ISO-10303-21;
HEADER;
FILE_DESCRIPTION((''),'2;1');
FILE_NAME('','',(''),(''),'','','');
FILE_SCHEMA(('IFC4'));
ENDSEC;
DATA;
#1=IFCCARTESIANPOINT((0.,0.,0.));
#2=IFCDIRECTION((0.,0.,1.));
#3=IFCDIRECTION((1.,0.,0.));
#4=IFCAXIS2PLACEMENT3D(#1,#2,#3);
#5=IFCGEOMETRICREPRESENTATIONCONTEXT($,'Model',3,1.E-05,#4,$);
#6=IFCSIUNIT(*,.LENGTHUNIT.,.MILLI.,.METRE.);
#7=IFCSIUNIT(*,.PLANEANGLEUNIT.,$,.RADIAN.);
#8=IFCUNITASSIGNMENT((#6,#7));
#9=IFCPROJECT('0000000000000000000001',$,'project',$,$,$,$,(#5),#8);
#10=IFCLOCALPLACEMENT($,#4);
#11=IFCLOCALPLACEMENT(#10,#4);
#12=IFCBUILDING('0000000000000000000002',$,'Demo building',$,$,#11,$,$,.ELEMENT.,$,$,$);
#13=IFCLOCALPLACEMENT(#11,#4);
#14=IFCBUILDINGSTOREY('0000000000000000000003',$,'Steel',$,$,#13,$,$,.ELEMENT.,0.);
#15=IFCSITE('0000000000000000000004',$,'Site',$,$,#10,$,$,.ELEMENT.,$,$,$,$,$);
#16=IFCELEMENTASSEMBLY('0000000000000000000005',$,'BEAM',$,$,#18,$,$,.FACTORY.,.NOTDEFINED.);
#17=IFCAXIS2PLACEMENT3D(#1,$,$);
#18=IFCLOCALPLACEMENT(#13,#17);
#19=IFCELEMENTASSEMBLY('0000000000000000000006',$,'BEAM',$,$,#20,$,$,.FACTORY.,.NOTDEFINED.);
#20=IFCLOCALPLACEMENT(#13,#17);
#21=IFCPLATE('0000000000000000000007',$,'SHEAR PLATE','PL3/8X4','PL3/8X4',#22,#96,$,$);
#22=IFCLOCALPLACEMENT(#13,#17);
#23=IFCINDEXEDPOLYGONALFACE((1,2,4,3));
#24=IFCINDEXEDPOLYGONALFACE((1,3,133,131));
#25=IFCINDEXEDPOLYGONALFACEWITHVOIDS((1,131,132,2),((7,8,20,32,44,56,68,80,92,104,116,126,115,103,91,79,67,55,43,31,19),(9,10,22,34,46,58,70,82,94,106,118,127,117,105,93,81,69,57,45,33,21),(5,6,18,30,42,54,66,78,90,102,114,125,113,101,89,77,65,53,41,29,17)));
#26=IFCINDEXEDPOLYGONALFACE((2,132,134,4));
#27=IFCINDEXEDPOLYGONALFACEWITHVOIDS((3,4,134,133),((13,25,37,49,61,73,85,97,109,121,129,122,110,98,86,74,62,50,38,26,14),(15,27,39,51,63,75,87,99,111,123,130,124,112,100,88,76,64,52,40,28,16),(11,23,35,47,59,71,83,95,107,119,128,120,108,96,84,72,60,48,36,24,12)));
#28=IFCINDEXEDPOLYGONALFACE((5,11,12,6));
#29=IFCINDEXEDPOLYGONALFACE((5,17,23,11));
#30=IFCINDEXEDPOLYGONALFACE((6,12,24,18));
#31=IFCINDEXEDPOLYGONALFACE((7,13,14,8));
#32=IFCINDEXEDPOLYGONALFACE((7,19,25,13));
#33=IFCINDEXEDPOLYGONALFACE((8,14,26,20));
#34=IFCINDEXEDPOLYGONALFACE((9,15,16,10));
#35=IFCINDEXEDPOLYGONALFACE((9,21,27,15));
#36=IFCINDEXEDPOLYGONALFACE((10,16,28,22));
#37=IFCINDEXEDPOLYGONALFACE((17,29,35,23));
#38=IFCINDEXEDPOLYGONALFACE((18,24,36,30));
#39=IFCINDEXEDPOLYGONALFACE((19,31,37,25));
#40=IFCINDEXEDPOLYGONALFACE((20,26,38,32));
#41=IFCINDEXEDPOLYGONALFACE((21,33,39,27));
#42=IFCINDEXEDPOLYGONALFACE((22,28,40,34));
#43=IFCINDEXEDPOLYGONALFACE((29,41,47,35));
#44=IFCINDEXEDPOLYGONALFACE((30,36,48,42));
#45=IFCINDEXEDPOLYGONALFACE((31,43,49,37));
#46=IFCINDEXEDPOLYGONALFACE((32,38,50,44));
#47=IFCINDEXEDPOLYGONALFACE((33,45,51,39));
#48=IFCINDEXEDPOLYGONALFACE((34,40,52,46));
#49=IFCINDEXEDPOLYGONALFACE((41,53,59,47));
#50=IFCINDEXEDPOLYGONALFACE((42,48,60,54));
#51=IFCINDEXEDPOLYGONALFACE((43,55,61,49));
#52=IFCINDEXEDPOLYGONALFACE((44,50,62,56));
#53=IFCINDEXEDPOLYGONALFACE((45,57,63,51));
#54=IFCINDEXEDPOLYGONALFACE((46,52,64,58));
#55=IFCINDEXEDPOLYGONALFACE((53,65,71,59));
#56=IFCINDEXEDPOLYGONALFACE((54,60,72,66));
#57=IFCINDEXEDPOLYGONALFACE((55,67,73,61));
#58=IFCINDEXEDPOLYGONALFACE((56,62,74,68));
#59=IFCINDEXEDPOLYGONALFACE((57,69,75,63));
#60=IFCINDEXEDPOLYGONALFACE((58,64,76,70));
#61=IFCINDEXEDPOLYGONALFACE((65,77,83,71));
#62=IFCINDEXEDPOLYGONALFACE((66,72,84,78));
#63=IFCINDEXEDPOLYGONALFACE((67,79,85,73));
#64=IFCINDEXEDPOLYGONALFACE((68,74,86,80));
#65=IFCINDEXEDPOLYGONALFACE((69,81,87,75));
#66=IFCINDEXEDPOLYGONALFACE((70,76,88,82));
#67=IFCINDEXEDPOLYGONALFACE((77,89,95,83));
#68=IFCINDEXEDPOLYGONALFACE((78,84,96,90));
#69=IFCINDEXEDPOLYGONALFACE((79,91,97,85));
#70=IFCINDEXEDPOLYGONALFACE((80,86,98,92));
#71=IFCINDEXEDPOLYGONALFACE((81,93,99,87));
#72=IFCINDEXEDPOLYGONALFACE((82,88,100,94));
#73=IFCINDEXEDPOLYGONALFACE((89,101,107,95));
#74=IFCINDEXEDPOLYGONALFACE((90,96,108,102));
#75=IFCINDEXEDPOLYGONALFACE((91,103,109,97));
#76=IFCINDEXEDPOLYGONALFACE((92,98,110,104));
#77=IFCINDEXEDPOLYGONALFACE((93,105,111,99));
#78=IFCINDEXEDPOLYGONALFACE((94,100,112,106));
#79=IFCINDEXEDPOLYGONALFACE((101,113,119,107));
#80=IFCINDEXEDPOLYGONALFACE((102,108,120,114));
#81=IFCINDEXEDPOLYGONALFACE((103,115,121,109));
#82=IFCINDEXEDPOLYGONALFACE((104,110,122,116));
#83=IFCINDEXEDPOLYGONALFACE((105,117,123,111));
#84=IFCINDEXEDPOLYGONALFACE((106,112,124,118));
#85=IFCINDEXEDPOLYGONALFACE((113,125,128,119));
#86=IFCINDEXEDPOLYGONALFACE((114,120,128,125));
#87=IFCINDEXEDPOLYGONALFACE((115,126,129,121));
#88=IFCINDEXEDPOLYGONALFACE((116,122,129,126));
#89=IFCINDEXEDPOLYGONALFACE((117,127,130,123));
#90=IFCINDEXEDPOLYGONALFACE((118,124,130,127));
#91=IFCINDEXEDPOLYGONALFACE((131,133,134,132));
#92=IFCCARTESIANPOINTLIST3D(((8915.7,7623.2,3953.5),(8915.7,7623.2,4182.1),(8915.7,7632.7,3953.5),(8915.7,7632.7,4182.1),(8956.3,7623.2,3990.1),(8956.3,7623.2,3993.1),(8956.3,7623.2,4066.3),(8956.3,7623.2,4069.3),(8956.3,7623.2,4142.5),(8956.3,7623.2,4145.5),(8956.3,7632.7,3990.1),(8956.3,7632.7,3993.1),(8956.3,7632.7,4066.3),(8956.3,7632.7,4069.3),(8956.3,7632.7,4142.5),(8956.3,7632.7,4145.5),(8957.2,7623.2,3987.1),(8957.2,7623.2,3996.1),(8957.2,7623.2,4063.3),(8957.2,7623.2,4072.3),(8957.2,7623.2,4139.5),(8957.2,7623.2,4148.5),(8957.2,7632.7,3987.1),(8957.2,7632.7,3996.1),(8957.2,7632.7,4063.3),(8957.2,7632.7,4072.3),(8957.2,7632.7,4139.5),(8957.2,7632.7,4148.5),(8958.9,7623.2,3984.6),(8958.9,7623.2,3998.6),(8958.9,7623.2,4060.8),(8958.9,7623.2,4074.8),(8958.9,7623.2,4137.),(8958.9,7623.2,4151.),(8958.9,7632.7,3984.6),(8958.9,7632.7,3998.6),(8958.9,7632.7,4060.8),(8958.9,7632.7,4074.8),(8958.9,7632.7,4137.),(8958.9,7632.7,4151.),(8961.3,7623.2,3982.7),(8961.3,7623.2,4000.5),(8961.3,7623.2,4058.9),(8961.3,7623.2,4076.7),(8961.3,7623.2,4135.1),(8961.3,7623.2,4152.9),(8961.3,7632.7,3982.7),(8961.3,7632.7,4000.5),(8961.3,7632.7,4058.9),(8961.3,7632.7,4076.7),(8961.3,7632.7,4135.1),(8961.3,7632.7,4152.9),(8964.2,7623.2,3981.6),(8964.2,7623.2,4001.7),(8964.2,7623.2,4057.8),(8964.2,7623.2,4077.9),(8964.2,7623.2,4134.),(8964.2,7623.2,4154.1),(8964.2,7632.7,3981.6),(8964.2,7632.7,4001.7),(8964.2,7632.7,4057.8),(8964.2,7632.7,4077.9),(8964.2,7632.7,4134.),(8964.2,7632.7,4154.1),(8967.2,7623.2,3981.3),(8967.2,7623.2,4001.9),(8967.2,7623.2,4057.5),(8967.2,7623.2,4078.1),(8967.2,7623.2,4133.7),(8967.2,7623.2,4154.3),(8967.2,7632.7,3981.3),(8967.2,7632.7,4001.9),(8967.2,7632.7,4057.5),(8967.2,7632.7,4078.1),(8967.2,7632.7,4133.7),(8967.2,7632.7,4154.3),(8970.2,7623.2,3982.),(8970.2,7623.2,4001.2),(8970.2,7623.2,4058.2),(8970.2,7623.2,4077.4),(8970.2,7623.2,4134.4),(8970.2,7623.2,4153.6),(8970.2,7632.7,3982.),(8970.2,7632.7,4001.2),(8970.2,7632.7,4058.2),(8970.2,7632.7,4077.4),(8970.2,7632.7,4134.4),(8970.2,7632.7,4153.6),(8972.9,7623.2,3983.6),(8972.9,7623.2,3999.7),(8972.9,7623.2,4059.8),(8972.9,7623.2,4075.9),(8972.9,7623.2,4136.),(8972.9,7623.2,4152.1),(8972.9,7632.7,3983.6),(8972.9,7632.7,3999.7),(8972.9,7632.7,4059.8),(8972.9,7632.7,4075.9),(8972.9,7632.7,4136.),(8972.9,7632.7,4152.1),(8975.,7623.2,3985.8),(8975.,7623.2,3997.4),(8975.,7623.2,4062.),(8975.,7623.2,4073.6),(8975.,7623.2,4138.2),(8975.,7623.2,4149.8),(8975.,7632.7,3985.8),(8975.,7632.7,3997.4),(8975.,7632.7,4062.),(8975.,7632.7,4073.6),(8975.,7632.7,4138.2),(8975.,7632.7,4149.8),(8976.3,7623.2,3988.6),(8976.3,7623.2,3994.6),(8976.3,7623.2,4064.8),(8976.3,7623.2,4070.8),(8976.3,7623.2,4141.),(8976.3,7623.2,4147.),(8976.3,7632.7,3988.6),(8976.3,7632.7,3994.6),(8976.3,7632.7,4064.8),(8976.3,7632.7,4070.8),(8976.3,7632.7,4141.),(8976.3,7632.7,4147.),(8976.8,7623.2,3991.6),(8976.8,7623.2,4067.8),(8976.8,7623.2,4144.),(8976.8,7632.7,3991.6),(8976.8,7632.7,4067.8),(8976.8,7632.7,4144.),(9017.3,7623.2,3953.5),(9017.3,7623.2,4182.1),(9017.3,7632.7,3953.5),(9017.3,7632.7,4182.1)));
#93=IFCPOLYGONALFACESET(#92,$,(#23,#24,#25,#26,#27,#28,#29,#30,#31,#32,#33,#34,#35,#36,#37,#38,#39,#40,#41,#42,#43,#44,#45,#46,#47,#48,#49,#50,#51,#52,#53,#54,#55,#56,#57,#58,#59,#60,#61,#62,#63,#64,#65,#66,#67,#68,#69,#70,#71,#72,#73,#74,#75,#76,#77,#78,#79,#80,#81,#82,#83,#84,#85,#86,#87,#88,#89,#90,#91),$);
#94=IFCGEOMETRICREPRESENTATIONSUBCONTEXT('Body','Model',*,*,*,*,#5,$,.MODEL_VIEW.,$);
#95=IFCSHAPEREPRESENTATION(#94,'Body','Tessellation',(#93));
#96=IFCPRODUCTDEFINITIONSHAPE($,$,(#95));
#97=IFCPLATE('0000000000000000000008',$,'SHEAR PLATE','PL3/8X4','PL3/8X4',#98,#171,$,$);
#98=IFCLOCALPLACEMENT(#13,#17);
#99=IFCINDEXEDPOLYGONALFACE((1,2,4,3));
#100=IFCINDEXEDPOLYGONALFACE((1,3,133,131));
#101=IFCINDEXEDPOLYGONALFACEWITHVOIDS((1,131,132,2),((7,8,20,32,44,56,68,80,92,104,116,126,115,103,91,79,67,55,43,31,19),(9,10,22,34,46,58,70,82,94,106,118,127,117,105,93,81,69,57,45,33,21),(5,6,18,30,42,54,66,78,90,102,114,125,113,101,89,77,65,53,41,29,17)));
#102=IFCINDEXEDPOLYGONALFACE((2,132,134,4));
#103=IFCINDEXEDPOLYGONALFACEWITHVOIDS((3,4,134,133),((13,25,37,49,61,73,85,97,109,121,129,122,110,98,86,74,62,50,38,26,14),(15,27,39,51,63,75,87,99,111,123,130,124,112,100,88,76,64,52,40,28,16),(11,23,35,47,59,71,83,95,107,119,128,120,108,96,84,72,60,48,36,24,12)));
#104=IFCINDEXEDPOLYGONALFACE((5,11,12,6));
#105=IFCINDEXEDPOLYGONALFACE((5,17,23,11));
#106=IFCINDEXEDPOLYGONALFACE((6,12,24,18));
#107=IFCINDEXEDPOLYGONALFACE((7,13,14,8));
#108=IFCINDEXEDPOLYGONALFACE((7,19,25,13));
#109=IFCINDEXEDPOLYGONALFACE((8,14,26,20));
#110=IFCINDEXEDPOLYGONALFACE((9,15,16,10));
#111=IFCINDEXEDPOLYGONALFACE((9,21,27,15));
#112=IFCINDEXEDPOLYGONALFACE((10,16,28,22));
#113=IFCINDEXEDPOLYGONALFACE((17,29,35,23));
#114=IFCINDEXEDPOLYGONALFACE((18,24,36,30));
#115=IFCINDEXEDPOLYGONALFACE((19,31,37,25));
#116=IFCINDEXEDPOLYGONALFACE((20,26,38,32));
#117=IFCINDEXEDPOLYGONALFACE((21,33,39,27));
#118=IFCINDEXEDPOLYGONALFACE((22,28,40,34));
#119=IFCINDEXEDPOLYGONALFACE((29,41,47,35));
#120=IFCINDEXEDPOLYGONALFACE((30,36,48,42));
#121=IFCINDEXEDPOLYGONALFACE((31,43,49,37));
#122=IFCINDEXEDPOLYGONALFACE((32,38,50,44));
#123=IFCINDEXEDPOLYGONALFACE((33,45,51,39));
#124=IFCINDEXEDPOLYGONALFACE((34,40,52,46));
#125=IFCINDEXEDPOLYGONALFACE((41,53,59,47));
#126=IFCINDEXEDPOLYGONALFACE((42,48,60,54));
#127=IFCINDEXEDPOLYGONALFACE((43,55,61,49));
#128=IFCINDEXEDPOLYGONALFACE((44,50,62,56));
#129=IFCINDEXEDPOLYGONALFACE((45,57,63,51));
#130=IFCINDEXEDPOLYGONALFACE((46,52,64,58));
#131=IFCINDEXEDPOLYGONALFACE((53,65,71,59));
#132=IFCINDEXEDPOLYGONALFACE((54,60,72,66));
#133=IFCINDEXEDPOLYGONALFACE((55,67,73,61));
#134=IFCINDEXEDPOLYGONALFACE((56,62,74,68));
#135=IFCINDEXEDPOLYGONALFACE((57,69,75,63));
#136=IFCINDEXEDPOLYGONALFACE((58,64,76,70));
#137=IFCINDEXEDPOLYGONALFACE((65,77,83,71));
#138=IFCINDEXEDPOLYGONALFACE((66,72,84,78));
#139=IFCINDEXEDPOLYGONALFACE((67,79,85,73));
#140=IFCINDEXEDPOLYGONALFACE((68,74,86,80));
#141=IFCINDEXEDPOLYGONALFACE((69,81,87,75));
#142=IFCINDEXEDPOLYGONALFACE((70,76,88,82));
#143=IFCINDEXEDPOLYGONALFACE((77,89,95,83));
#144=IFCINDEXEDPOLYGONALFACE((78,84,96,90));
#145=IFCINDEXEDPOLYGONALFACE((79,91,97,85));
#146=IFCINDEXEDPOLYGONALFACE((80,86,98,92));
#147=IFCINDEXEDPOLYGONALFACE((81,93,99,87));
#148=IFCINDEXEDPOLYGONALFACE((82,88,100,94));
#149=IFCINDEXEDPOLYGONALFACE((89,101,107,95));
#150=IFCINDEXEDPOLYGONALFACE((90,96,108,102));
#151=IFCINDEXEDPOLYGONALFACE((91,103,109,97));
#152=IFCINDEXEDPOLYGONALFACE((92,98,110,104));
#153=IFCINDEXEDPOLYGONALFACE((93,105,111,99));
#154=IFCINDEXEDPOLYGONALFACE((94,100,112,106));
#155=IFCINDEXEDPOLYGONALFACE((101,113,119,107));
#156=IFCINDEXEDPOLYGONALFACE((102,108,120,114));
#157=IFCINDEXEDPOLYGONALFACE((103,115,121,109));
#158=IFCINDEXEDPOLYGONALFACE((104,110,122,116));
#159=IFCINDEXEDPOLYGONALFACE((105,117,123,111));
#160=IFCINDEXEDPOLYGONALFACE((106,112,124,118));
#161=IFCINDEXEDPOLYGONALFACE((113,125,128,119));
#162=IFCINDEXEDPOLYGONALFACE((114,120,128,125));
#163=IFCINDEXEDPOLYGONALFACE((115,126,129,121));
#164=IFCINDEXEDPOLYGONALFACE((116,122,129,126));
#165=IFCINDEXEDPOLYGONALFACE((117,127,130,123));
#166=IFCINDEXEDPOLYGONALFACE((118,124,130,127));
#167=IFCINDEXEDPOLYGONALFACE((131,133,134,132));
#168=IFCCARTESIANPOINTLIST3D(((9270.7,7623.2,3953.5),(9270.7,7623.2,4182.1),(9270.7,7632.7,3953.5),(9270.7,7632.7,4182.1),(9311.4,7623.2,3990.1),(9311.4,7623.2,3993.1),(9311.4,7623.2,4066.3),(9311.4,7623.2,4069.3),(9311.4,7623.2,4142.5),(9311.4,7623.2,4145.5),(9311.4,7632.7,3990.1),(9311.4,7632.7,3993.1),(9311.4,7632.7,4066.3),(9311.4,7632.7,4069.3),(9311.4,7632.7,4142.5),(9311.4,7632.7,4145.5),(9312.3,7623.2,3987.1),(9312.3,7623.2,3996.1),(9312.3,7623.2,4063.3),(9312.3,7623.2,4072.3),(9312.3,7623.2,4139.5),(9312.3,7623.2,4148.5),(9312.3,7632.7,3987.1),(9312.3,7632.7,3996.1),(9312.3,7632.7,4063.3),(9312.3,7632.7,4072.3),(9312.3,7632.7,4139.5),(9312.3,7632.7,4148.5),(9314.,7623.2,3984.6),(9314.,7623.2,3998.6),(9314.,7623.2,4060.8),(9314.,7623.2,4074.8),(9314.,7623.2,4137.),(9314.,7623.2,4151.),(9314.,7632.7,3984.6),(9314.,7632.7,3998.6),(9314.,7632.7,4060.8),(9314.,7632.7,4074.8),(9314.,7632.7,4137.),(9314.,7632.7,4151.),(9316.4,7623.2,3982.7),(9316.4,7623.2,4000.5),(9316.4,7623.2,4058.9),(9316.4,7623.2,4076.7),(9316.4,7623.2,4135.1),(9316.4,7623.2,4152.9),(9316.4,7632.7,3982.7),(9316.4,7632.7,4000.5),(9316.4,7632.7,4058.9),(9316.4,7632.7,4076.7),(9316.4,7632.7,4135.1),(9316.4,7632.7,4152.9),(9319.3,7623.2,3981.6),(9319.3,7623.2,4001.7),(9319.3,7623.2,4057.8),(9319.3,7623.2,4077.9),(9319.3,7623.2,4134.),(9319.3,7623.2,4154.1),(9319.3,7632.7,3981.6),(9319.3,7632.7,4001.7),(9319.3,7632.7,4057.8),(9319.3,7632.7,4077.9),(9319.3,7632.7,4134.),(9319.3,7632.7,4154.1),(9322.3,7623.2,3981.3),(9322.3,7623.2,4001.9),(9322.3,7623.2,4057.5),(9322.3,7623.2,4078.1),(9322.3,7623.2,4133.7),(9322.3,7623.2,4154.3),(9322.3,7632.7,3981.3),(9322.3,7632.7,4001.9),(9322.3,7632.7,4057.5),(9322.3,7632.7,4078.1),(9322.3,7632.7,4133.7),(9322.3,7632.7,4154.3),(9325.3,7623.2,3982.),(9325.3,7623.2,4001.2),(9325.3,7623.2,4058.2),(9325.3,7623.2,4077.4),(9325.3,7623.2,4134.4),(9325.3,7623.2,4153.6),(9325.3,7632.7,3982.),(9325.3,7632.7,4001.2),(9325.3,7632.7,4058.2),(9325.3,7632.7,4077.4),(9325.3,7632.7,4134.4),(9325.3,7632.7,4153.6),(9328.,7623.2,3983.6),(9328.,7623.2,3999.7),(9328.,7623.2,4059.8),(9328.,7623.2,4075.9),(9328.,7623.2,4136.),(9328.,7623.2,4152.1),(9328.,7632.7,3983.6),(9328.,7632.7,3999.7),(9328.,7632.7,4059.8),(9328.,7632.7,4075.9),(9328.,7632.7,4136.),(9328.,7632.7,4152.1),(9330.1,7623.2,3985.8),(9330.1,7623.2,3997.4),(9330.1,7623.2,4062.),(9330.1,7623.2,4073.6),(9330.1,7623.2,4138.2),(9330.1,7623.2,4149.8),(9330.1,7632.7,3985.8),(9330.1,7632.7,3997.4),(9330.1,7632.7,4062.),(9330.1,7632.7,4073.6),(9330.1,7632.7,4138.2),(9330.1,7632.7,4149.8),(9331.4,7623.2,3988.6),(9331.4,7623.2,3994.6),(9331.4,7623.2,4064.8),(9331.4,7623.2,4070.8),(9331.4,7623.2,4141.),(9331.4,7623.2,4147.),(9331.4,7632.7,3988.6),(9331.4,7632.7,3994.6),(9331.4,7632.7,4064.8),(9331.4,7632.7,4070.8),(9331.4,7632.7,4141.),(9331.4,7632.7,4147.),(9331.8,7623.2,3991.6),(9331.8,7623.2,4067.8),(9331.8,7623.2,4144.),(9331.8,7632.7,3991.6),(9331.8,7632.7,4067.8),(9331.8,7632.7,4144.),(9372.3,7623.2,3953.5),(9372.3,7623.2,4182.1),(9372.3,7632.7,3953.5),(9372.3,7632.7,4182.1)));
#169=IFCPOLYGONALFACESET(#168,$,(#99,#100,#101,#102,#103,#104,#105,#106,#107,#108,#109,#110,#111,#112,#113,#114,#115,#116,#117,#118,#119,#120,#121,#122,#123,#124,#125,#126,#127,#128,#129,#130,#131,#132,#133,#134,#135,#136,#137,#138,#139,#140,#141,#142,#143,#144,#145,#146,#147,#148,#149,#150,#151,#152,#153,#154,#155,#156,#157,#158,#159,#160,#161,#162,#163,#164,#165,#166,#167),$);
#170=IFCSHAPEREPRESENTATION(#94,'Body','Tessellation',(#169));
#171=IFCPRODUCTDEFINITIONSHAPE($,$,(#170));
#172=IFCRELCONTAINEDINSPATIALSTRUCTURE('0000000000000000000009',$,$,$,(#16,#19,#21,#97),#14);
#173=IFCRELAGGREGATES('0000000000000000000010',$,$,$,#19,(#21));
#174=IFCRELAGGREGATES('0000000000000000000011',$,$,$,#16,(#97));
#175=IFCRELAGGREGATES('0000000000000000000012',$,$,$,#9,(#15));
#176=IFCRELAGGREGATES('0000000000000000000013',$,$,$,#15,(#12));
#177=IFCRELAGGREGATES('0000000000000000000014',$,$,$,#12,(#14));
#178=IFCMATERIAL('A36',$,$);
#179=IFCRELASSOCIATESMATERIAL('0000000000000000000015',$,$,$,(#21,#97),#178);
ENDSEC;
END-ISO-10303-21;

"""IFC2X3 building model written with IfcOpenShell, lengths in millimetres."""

from ifc_helpers import new_model, si_unit, frame, frame_2d, origin, origin_with_axes, place, context, subcontext, project, spatial, rectangle, circle, extrude, boolean, material, element, aggregate, save


model = new_model("IFC2X3")

# Units and contexts
model_context = context("Model", 3, precision=1e-05, world=origin_with_axes())
body_context = subcontext(model_context, "Body", "Model", "MODEL_VIEW")
ifc_project = project(units=[si_unit("LENGTHUNIT", "METRE", prefix="MILLI"), si_unit("PLANEANGLEUNIT", "RADIAN")], contexts=[model_context])

# Site, building, storey
site_placement = place(None, origin_with_axes())
site = spatial("IfcSite", under=ifc_project, at=site_placement, Name="Site", CompositionType="ELEMENT")
building_placement = place(site_placement, origin_with_axes())
building = spatial("IfcBuilding", under=site, at=building_placement, Name="Demo building", CompositionType="ELEMENT")
placement = place(building_placement, origin_with_axes())
storey = spatial("IfcBuildingStorey", under=building, at=placement, Name="Steel", CompositionType="ELEMENT", Elevation=0.0)

# Element assembly
assembly_1 = element("IfcElementAssembly", 1, at=placement, inside=storey, Name="BEAM", AssemblyPlace="FACTORY", PredefinedType="NOTDEFINED")

# Shared definitions
ifc_material_1 = material(Name="A36")

# Element assembly, plate
assembly_2 = element("IfcElementAssembly", 2, at=placement, inside=storey, Name="BEAM", AssemblyPlace="FACTORY", PredefinedType="NOTDEFINED")
plate_1_placement = place(placement, frame((8915.7, 7632.7, 3953.5), z_axis=(0.0, -1.0, 0.0), x_axis=(1.0, 0.0, 0.0)))
plate_1 = element("IfcPlate", 3, at=plate_1_placement, inside=storey, material=ifc_material_1, Name="SHEAR PLATE", Description="PL3/8X4", ObjectType="PL3/8X4", context=body_context, shape_type="CSG", body=[
    boolean("DIFFERENCE", boolean("DIFFERENCE", boolean("DIFFERENCE", extrude(rectangle(XDim=101.6, YDim=228.6, at=frame_2d((50.8, 114.3))), origin(), (0.0, 0.0, 1.0), 9.5), extrude(circle(Radius=10.3, at=frame_2d((50.8, 38.1))), frame((0.0, 0.0, -5.0)), (0.0, 0.0, 1.0), 19.5)), extrude(circle(Radius=10.3, at=frame_2d((50.8, 114.3))), frame((0.0, 0.0, -5.0)), (0.0, 0.0, 1.0), 19.5)), extrude(circle(Radius=10.3, at=frame_2d((50.8, 190.5))), frame((0.0, 0.0, -5.0)), (0.0, 0.0, 1.0), 19.5)),
])
aggregate(assembly_2, [plate_1])

# Plate
plate_2_placement = place(placement, frame((9270.7, 7632.7, 3953.5), z_axis=(0.0, -1.0, 0.0), x_axis=(1.0, 0.0, 0.0)))
plate_2 = element("IfcPlate", 4, at=plate_2_placement, inside=storey, material=ifc_material_1, Name="SHEAR PLATE", Description="PL3/8X4", ObjectType="PL3/8X4", context=body_context, shape_type="CSG", body=[
    boolean("DIFFERENCE", boolean("DIFFERENCE", boolean("DIFFERENCE", extrude(rectangle(XDim=101.6, YDim=228.6, at=frame_2d((50.8, 114.3))), origin(), (0.0, 0.0, 1.0), 9.5), extrude(circle(Radius=10.3, at=frame_2d((50.8, 38.1))), frame((0.0, 0.0, -5.0)), (0.0, 0.0, 1.0), 19.5)), extrude(circle(Radius=10.3, at=frame_2d((50.8, 114.3))), frame((0.0, 0.0, -5.0)), (0.0, 0.0, 1.0), 19.5)), extrude(circle(Radius=10.3, at=frame_2d((50.8, 190.5))), frame((0.0, 0.0, -5.0)), (0.0, 0.0, 1.0), 19.5)),
])
aggregate(assembly_1, [plate_2])

save(model, "model.ifc")
